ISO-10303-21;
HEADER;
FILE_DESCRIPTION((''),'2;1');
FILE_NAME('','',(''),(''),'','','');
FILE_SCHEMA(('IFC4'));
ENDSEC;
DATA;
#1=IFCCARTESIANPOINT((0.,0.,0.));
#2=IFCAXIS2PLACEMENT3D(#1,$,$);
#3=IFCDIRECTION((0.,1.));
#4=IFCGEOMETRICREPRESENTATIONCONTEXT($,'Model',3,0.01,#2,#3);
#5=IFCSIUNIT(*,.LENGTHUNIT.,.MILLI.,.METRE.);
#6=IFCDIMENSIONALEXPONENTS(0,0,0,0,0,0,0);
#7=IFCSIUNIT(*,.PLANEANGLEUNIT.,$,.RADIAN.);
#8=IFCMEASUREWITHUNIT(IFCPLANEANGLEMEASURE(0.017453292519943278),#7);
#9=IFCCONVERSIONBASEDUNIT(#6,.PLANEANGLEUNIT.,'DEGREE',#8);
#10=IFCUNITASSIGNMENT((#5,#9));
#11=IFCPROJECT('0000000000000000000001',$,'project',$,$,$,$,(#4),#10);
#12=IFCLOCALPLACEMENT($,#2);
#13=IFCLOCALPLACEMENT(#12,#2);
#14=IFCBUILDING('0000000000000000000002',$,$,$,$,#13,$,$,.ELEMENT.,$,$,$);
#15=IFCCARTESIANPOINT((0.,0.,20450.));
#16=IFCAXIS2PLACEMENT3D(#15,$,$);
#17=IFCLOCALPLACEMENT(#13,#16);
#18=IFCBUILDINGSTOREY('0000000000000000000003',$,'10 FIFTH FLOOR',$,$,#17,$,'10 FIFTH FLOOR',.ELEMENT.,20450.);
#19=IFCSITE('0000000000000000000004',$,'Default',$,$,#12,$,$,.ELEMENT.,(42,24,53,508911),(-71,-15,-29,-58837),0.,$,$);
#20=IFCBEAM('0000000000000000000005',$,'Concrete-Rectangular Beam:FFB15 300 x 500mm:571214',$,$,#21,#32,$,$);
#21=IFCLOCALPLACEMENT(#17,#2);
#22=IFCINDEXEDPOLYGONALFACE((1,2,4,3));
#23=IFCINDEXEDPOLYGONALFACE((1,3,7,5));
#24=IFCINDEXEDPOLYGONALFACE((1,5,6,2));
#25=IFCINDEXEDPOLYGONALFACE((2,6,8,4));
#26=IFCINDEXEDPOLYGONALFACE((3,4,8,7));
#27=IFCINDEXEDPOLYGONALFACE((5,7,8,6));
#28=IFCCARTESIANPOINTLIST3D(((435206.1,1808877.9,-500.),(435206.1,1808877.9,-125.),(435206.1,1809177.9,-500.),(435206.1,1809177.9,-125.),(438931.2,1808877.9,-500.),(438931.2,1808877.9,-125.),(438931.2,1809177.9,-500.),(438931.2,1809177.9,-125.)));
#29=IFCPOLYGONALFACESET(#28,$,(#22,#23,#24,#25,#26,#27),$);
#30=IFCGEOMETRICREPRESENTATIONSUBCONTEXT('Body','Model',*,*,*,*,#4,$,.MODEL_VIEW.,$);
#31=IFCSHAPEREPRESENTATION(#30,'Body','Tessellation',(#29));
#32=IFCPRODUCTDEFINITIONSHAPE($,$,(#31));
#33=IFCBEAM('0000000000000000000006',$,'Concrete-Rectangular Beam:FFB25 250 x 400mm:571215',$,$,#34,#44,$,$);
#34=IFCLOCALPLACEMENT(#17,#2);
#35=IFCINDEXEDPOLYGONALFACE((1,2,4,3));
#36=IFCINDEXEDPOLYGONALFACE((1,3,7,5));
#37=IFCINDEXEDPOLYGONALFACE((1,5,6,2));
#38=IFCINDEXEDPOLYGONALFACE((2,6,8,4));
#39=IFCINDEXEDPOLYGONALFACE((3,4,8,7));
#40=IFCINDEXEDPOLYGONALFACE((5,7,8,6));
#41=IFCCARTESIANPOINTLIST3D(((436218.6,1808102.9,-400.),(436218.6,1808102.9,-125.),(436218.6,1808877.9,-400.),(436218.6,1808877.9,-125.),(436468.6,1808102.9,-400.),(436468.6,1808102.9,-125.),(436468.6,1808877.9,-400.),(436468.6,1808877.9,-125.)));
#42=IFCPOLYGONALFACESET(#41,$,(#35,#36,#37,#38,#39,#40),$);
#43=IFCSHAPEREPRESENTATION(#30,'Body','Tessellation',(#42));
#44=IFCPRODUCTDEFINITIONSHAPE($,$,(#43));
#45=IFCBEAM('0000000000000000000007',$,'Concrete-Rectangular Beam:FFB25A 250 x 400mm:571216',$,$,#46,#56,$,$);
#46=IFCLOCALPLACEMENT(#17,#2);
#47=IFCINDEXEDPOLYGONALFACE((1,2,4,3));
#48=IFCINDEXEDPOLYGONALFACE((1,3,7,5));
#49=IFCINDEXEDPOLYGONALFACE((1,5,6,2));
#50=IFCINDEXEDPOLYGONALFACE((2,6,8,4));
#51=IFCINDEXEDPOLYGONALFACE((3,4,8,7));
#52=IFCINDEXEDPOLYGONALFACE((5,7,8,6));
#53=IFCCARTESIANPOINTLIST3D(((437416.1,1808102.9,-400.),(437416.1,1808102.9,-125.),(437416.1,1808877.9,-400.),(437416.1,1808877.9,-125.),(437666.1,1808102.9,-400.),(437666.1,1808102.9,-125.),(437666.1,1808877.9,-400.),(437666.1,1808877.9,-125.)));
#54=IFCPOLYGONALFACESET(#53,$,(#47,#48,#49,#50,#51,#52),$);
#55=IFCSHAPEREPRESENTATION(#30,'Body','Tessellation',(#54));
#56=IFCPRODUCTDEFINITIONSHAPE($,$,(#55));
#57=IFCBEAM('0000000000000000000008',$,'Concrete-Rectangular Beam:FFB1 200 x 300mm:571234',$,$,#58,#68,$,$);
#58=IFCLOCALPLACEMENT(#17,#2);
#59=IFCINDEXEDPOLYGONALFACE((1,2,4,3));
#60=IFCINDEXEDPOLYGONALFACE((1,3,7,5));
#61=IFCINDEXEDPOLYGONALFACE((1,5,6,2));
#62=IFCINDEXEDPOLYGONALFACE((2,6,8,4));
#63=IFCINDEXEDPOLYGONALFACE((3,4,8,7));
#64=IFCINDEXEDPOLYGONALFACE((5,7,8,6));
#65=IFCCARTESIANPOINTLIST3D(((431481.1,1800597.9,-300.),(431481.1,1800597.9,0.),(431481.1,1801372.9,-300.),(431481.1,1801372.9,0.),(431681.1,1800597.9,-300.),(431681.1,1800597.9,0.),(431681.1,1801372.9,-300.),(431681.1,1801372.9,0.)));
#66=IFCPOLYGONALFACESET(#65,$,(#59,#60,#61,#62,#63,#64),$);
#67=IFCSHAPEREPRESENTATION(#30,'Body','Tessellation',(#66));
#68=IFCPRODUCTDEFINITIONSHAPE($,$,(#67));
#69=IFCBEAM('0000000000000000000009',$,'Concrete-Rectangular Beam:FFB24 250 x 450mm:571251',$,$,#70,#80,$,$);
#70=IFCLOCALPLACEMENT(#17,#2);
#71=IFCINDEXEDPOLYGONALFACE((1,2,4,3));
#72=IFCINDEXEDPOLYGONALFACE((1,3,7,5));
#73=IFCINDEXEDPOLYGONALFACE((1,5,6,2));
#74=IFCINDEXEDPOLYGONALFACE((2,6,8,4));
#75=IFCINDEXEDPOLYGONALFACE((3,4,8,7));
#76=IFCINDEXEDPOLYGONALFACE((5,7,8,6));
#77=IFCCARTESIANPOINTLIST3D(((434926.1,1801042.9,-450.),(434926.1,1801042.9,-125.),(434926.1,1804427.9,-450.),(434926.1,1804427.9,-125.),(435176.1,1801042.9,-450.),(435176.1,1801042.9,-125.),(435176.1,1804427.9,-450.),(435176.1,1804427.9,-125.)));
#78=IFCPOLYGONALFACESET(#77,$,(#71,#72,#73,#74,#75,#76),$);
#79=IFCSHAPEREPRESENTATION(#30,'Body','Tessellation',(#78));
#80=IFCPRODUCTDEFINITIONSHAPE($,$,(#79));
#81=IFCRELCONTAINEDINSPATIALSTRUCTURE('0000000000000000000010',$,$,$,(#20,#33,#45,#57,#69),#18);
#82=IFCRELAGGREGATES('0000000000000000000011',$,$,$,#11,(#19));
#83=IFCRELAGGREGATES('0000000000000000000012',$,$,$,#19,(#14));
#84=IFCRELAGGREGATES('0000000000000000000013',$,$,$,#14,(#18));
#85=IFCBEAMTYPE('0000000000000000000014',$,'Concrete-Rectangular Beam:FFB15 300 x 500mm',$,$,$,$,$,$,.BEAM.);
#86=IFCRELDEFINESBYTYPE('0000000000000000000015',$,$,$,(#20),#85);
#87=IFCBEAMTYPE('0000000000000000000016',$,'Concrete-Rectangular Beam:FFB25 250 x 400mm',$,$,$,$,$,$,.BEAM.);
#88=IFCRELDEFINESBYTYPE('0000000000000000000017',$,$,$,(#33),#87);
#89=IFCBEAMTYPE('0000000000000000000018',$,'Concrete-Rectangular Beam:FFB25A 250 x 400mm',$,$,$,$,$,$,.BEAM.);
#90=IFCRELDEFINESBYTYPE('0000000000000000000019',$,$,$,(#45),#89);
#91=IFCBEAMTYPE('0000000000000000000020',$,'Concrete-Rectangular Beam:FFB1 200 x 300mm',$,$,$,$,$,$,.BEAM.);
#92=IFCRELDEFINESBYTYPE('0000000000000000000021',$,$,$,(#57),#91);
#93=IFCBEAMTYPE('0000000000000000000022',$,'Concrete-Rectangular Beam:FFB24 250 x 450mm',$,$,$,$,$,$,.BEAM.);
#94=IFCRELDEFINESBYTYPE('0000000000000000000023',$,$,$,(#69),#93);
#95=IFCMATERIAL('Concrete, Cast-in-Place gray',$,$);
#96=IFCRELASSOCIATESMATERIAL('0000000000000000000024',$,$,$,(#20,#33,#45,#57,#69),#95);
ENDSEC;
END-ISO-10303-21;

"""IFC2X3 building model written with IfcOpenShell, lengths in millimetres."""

from ifc_helpers import new_model, entity, si_unit, converted_unit, direction, frame, frame_2d, origin, origin_2d_with_axis, place, context, subcontext, project, spatial, rectangle, extrude, material, type_object, element, save


model = new_model("IFC2X3")

# Units and contexts
model_context = context("Model", 3, precision=0.01, world=origin(), true_north=direction((0.0, 1.0)))
body_context = subcontext(model_context, "Body", "Model", "MODEL_VIEW")
ifc_project = project(units=[si_unit("LENGTHUNIT", "METRE", prefix="MILLI"), converted_unit("PLANEANGLEUNIT", "DEGREE", entity("IfcPlaneAngleMeasure", 0.017453292519943278), si_unit("PLANEANGLEUNIT", "RADIAN"), dimensions=[0, 0, 0, 0, 0, 0, 0])], contexts=[model_context])

# Site, building, storey
site_placement = place(None, origin())
site = spatial("IfcSite", under=ifc_project, at=site_placement, Name="Default", CompositionType="ELEMENT", RefLatitude=(42, 24, 53, 508911), RefLongitude=(-71, -15, -29, -58837), RefElevation=0.0)
building_placement = place(site_placement, origin())
building = spatial("IfcBuilding", under=site, at=building_placement, CompositionType="ELEMENT")
storey_placement = place(building_placement, frame((0.0, 0.0, 20450.0)))
storey = spatial("IfcBuildingStorey", under=building, at=storey_placement, Name="10 FIFTH FLOOR", LongName="10 FIFTH FLOOR", CompositionType="ELEMENT", Elevation=20450.0)

# Beams
ifc_material = material(Name="Concrete, Cast-in-Place gray")
beam_type_1 = type_object("IfcBeamType", Name="Concrete-Rectangular Beam:FFB15 300 x 500mm", PredefinedType="BEAM")
beam_1_placement = place(storey_placement, frame((435206.1, 1808877.9, 0.0)))
element("IfcBeam", 1, at=beam_1_placement, inside=storey, type_object=beam_type_1, material=ifc_material, Name="Concrete-Rectangular Beam:FFB15 300 x 500mm:571214", context=body_context, shape_type="SweptSolid", body=[
    extrude(rectangle(XDim=375.0, YDim=300.0, at=frame_2d((0.0, 0.0), x_axis=(1.0, 0.0))), frame((0.0, 150.0, -312.5), z_axis=(1.0, 0.0, 0.0), x_axis=(0.0, 0.0, -1.0)), (0.0, 0.0, 1.0), 3725.1),
])
beam_type_2 = type_object("IfcBeamType", Name="Concrete-Rectangular Beam:FFB25 250 x 400mm", PredefinedType="BEAM")
beam_2_placement = place(storey_placement, frame((436218.6, 1808877.9, 0.0), z_axis=(0.0, 0.0, 1.0), x_axis=(0.0, -1.0, 0.0)))
element("IfcBeam", 2, at=beam_2_placement, inside=storey, type_object=beam_type_2, material=ifc_material, Name="Concrete-Rectangular Beam:FFB25 250 x 400mm:571215", context=body_context, shape_type="SweptSolid", body=[
    extrude(rectangle(XDim=275.0, YDim=250.0, at=frame_2d((0.0, 0.0), x_axis=(1.0, 0.0))), frame((0.0, 125.0, -262.5), z_axis=(1.0, 0.0, 0.0), x_axis=(0.0, 0.0, -1.0)), (0.0, 0.0, 1.0), 775.0),
])
beam_type_3 = type_object("IfcBeamType", Name="Concrete-Rectangular Beam:FFB25A 250 x 400mm", PredefinedType="BEAM")
beam_3_placement = place(storey_placement, frame((437416.1, 1808877.9, 0.0), z_axis=(0.0, 0.0, 1.0), x_axis=(0.0, -1.0, 0.0)))
element("IfcBeam", 3, at=beam_3_placement, inside=storey, type_object=beam_type_3, material=ifc_material, Name="Concrete-Rectangular Beam:FFB25A 250 x 400mm:571216", context=body_context, shape_type="SweptSolid", body=[
    extrude(rectangle(XDim=275.0, YDim=250.0, at=frame_2d((0.0, 0.0), x_axis=(1.0, 0.0))), frame((0.0, 125.0, -262.5), z_axis=(1.0, 0.0, 0.0), x_axis=(0.0, 0.0, -1.0)), (0.0, 0.0, 1.0), 775.0),
])
beam_type_4 = type_object("IfcBeamType", Name="Concrete-Rectangular Beam:FFB1 200 x 300mm", PredefinedType="BEAM")
beam_4_placement = place(storey_placement, frame((431681.1, 1801372.9, 0.0), z_axis=(0.0, 0.0, 1.0), x_axis=(0.0, -1.0, 0.0)))
element("IfcBeam", 4, at=beam_4_placement, inside=storey, type_object=beam_type_4, material=ifc_material, Name="Concrete-Rectangular Beam:FFB1 200 x 300mm:571234", context=body_context, shape_type="SweptSolid", body=[
    extrude(rectangle(XDim=300.0, YDim=200.0, at=origin_2d_with_axis()), frame((0.0, -100.0, -150.0), z_axis=(1.0, 0.0, 0.0), x_axis=(0.0, 0.0, -1.0)), (0.0, 0.0, 1.0), 775.0),
])
beam_type_5 = type_object("IfcBeamType", Name="Concrete-Rectangular Beam:FFB24 250 x 450mm", PredefinedType="BEAM")
beam_5_placement = place(storey_placement, frame((435176.1, 1804427.9, 0.0), z_axis=(0.0, 0.0, 1.0), x_axis=(0.0, -1.0, 0.0)))
element("IfcBeam", 5, at=beam_5_placement, inside=storey, type_object=beam_type_5, material=ifc_material, Name="Concrete-Rectangular Beam:FFB24 250 x 450mm:571251", context=body_context, shape_type="SweptSolid", body=[
    extrude(rectangle(XDim=325.0, YDim=250.0, at=frame_2d((0.0, 0.0), x_axis=(1.0, 0.0))), frame((0.0, -125.0, -287.5), z_axis=(1.0, 0.0, 0.0), x_axis=(0.0, 0.0, -1.0)), (0.0, 0.0, 1.0), 3385.0),
])

save(model, "model.ifc")
